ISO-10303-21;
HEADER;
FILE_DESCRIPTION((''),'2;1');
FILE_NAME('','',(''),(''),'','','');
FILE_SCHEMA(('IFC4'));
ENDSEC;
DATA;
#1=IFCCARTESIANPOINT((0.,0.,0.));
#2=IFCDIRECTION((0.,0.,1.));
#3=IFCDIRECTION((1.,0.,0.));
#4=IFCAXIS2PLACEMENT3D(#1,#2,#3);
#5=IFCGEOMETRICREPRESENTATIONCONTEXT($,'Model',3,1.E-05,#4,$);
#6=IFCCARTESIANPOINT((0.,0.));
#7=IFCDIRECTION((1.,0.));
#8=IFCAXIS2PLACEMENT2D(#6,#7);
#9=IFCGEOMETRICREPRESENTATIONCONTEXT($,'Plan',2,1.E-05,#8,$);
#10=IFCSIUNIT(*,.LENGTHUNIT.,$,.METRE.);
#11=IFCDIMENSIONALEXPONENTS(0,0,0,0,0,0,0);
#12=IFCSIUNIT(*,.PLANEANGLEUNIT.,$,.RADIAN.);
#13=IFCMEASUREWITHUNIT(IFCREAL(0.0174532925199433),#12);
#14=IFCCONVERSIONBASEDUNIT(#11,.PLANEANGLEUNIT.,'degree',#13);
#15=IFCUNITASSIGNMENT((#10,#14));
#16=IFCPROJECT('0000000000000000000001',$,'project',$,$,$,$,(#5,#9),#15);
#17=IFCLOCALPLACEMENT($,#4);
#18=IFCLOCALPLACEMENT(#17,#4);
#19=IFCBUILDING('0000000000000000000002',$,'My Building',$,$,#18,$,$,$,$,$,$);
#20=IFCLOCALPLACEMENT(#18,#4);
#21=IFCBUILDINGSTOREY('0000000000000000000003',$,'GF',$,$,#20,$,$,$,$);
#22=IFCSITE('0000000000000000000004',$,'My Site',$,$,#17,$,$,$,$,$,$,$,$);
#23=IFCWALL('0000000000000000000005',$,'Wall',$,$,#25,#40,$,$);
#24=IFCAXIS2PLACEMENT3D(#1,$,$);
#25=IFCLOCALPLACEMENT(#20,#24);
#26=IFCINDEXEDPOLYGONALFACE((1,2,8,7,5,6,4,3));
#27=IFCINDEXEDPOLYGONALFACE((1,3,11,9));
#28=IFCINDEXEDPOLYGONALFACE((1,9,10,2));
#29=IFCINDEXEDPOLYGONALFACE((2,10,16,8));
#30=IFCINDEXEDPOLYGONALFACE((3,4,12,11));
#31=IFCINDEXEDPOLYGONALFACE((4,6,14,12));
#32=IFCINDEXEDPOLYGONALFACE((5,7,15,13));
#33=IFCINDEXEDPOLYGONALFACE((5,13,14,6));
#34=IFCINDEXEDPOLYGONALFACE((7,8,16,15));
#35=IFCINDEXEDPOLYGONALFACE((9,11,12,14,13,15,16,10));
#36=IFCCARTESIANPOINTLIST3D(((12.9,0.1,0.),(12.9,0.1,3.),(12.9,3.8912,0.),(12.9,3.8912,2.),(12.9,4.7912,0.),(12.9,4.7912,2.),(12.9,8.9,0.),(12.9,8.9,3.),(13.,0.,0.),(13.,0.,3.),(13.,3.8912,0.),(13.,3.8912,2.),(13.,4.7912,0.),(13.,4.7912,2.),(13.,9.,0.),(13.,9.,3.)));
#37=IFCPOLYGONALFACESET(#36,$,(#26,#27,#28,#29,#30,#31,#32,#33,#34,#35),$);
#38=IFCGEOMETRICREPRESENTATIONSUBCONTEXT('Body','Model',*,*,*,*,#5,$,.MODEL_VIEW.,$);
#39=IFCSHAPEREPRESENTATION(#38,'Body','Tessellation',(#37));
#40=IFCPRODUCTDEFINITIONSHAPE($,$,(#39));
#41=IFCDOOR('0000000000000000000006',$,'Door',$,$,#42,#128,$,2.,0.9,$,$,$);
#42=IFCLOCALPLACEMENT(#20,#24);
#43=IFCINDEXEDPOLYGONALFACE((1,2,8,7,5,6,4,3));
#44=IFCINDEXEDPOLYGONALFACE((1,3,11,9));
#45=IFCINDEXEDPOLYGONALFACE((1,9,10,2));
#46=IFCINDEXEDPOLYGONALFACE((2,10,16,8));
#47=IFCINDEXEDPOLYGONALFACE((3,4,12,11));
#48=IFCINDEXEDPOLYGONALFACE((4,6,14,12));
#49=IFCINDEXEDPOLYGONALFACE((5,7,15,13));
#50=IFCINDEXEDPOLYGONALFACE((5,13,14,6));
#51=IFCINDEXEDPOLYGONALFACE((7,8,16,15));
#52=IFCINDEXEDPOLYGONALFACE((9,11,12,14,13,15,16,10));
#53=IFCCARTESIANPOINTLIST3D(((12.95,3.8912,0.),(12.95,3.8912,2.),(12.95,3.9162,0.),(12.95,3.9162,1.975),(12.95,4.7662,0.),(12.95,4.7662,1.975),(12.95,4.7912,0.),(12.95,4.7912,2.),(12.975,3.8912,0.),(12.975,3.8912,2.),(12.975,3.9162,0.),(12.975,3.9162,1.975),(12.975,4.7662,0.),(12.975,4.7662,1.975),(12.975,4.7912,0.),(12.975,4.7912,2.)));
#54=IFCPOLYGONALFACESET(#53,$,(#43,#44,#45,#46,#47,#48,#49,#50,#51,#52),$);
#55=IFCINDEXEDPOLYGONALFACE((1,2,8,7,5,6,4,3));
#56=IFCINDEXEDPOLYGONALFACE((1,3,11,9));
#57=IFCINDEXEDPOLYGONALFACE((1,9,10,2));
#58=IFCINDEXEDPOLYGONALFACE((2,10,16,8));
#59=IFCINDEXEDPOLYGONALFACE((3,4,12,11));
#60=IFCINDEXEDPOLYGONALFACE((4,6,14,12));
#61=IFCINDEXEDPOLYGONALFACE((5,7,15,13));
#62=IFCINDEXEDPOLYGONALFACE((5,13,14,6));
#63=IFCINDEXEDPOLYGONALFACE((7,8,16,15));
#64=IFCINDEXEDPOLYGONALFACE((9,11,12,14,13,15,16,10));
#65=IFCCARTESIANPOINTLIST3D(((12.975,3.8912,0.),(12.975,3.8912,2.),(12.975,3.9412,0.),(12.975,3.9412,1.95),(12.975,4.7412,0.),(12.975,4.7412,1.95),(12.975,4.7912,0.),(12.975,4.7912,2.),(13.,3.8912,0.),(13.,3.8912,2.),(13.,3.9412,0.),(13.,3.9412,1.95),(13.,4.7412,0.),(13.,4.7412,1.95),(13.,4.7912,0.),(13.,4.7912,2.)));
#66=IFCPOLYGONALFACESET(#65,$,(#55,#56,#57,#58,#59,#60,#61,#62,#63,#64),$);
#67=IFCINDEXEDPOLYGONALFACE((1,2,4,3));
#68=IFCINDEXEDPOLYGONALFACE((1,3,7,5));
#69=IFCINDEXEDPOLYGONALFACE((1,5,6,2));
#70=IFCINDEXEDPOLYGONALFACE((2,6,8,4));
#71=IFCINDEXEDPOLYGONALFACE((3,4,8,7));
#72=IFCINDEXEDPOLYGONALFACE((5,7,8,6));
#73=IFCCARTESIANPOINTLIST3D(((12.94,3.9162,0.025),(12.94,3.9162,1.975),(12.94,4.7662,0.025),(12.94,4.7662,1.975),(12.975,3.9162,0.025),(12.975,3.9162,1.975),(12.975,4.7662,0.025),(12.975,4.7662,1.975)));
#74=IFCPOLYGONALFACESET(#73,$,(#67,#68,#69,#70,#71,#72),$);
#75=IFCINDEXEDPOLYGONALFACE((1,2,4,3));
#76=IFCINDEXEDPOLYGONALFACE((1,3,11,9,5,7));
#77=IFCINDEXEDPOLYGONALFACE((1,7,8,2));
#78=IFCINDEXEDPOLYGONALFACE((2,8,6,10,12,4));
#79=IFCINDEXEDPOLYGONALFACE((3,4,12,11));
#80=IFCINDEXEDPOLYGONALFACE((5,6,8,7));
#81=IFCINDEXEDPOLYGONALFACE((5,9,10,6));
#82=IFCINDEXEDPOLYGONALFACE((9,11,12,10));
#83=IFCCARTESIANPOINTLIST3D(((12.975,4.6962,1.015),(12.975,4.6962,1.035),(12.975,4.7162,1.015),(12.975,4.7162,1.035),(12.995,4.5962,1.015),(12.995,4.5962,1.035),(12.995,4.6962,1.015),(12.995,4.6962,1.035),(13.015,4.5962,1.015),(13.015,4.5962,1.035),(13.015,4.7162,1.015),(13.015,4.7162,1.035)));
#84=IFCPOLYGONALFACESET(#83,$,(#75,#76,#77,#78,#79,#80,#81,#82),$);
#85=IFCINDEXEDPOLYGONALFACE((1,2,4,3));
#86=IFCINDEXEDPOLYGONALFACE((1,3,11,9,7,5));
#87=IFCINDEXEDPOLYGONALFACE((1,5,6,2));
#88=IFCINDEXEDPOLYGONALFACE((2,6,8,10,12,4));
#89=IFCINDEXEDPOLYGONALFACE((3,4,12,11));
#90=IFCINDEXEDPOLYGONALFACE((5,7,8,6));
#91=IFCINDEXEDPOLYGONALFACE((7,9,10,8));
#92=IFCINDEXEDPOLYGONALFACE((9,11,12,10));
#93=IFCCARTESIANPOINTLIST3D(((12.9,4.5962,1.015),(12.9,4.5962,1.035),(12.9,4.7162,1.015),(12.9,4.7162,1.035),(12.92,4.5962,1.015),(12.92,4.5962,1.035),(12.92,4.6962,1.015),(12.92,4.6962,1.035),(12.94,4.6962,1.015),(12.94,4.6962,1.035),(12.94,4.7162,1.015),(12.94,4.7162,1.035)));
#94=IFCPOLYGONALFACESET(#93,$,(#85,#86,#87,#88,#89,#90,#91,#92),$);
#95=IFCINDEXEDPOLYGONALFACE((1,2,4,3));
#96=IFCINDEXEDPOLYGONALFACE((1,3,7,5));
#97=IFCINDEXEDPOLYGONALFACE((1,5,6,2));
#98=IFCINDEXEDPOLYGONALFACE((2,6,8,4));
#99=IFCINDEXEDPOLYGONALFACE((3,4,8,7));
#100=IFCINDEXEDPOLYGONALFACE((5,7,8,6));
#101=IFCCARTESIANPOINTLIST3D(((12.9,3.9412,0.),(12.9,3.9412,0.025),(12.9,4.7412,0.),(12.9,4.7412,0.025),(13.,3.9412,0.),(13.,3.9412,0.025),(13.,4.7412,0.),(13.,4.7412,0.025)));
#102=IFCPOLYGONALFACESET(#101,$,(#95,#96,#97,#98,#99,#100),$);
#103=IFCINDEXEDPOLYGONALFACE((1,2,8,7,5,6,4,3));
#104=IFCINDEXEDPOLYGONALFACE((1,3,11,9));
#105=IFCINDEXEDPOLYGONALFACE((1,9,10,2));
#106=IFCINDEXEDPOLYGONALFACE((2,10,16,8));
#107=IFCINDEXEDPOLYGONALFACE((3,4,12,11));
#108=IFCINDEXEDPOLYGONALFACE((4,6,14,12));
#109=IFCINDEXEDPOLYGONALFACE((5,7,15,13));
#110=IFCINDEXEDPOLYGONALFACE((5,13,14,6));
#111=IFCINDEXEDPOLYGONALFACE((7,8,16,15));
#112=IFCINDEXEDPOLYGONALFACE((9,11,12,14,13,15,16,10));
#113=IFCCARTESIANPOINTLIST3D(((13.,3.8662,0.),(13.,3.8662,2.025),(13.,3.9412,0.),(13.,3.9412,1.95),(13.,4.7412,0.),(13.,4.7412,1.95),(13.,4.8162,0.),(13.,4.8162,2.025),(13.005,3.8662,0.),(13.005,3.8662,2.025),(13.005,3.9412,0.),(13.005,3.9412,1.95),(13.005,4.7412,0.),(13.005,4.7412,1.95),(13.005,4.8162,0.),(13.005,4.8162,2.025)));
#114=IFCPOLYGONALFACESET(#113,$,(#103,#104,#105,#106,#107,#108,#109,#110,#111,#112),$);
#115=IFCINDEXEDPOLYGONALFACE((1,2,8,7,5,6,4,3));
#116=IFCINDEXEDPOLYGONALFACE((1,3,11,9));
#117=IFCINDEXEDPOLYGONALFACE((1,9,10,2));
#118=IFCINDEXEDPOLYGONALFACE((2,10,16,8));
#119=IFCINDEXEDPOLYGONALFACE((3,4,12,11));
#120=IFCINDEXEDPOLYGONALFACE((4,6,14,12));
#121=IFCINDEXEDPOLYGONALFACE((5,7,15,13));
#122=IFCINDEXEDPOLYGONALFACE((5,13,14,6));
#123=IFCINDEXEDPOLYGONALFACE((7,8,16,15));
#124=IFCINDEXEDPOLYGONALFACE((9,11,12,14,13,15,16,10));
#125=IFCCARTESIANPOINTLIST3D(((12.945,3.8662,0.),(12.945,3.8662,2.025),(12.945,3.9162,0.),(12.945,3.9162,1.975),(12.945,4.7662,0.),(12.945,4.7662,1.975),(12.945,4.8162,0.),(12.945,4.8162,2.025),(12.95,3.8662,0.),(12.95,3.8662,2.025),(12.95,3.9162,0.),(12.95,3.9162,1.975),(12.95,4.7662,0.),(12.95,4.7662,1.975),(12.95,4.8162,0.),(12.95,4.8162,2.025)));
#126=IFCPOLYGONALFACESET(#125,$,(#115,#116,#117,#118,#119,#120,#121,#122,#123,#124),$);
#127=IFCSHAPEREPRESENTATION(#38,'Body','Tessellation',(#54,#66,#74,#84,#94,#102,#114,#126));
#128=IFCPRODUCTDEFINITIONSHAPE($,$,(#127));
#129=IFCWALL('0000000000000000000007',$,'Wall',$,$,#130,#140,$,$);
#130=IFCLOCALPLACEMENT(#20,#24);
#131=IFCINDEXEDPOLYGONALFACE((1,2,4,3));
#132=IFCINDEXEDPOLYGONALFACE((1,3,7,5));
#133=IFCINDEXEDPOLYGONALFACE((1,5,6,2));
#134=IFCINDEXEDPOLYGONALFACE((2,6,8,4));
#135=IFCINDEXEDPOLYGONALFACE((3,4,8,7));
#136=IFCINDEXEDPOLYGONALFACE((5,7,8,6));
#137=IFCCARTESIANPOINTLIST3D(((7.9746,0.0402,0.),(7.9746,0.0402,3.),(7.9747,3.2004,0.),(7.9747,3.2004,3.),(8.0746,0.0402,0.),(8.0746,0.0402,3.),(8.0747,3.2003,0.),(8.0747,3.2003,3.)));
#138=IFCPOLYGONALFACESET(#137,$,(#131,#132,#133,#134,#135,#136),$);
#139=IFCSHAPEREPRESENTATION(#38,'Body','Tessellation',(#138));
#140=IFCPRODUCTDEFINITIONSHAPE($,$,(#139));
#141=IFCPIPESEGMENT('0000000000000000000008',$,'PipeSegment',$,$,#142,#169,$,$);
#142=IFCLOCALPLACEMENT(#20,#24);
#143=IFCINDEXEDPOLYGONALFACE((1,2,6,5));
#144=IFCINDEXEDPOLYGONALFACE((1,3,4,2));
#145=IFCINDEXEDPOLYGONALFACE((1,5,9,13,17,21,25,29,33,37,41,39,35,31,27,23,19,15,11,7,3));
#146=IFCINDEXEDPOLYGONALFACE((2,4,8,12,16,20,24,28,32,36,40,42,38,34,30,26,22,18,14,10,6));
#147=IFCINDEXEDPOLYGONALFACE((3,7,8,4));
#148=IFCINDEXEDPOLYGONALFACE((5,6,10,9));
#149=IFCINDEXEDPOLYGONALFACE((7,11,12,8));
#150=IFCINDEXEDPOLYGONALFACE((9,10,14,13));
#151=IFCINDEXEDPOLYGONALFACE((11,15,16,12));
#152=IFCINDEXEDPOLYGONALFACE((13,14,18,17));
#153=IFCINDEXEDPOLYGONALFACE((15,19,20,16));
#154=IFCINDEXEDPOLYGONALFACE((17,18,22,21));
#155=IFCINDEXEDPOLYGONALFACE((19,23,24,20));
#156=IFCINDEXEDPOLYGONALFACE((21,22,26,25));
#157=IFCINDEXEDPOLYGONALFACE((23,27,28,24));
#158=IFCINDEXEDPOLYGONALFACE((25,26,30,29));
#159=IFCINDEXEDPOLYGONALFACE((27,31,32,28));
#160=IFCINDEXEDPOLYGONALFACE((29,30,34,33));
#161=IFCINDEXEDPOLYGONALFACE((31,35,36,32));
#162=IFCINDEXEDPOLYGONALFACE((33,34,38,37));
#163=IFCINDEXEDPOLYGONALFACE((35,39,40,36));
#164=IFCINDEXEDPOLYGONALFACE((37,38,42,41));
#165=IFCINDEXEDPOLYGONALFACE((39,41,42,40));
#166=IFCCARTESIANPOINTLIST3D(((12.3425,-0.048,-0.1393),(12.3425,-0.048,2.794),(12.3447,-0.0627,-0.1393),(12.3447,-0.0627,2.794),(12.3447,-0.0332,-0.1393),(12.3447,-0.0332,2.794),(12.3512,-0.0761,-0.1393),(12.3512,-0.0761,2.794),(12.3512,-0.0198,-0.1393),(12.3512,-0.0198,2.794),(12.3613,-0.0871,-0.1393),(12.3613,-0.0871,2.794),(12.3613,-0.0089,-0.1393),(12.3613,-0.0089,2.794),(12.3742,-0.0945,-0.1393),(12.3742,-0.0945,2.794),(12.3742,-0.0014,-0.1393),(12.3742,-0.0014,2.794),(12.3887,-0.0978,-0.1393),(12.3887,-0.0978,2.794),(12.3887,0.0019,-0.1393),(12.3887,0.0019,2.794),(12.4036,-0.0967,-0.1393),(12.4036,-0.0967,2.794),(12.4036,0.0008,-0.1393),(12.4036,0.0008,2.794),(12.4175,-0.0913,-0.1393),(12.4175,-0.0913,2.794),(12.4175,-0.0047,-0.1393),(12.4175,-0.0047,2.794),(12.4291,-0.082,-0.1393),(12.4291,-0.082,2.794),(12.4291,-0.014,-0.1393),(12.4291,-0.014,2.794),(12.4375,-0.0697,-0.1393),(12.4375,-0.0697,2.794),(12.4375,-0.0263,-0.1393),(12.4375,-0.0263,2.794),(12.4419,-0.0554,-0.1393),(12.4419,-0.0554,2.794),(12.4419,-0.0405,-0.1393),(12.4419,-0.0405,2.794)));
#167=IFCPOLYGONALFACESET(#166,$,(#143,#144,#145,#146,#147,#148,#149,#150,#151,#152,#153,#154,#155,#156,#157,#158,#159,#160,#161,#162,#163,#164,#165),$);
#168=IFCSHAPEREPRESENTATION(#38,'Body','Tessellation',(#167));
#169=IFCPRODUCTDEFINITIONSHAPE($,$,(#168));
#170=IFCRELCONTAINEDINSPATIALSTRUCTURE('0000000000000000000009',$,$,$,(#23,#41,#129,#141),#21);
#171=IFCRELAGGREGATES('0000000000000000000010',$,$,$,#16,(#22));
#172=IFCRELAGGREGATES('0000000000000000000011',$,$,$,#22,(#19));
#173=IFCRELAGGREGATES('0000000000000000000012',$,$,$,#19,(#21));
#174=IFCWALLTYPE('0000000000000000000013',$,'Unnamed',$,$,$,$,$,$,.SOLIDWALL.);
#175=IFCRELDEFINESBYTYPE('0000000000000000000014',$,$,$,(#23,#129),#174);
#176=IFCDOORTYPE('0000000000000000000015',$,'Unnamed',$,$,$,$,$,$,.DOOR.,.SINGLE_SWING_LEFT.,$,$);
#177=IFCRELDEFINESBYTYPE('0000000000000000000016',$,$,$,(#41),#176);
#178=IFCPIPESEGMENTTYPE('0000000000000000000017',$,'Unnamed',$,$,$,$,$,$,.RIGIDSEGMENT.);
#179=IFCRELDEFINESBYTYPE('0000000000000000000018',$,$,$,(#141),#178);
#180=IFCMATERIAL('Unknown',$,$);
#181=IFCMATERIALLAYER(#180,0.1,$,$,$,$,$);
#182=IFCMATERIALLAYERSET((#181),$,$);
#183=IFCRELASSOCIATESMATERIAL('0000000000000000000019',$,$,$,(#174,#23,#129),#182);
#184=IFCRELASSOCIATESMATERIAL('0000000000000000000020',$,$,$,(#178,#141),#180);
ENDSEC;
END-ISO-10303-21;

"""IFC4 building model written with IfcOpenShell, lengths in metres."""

from ifc_helpers import new_model, entity, si_unit, converted_unit, frame, origin_with_axes, origin_2d_with_axis, place, context, subcontext, project, spatial, line, indexed_curve, circle, outline, extrude, shape, source, transform, mapped, material, layer, layer_set, layer_usage, material_profile, profile_set, profile_usage, type_object, type_shapes, element, fill, save


model = new_model("IFC4")

# Units and contexts
model_context = context("Model", 3, precision=1e-05, world=origin_with_axes())
plan_context = context("Plan", 2, precision=1e-05, world=origin_2d_with_axis())
body_context_1 = subcontext(model_context, "Body", "Model", "MODEL_VIEW")
body_context_2 = subcontext(plan_context, "Body", "Plan", "PLAN_VIEW")
ifc_project = project(units=[si_unit("LENGTHUNIT", "METRE"), converted_unit("PLANEANGLEUNIT", "degree", entity("IfcReal", 0.0174532925199433), si_unit("PLANEANGLEUNIT", "RADIAN"), dimensions=[0, 0, 0, 0, 0, 0, 0])], contexts=[model_context, plan_context])

# Site, building, storey
site_placement = place(None, origin_with_axes())
site = spatial("IfcSite", under=ifc_project, at=site_placement, Name="My Site")
building_placement = place(site_placement, origin_with_axes())
building = spatial("IfcBuilding", under=site, at=building_placement, Name="My Building")
storey_placement = place(building_placement, origin_with_axes())
storey = spatial("IfcBuildingStorey", under=building, at=storey_placement, Name="GF")

# Wall, opening, door
ifc_material = material(Name="Unknown")
ifc_layer = layer(ifc_material, 0.1)
ifc_layer_set = layer_set([ifc_layer])
ifc_layer_usage_1 = layer_usage(ifc_layer_set, "AXIS2", "POSITIVE", 0.0)
wall_type = type_object("IfcWallType", Name="Unnamed", PredefinedType="SOLIDWALL", material=ifc_layer_set)
wall_1_placement = place(storey_placement, frame((13.0, 0.0, 0.0), z_axis=(0.0, 0.0, 1.0), x_axis=(0.0, 1.0, 0.0)))
wall_1 = element("IfcWall", 1, at=wall_1_placement, inside=storey, type_object=wall_type, material=ifc_layer_usage_1, Name="Wall", context=body_context_1, shape_type="SweptSolid", body=[
    extrude(outline(indexed_curve([(0.0, 0.0), (0.1, 0.1), (8.9, 0.1), (9.0, 0.0)], segments=[line(1, 2, 3, 4, 1)])), origin_with_axes(), (0.0, 0.0, 1.0), 3.0),
])
shared_shape_1 = source(origin_with_axes(), body_context_1, "Body", "SweptSolid", [
    extrude(outline(indexed_curve([(0.0, 0.0), (0.9, 0.0), (0.9, 2.0), (0.0, 2.0)], segments=[line(1, 2, 3, 4, 1)])), frame((0.0, -0.6, 0.0), z_axis=(0.0, -1.0, 0.0), x_axis=(1.0, 0.0, 0.0)), (0.0, 0.0, -1.0), 1.2),
])
opening_1_placement = place(wall_1_placement, frame((3.8912, 0.0, 0.0), z_axis=(0.0, 0.0, 1.0), x_axis=(1.0, 0.0, 0.0)))
opening_1 = element("IfcOpeningElement", 2, at=opening_1_placement, cuts=wall_1, PredefinedType="OPENING", context=body_context_1, shape_type="MappedRepresentation", body=[
    mapped(shared_shape_1, transform((0.0, 0.0, 0.0), x_axis=(1.0, 0.0, 0.0), y_axis=(0.0, 1.0, 0.0), z_axis=(0.0, 0.0, 1.0), scale=1.0)),
])
door_type = type_object("IfcDoorType", Name="Unnamed", OperationType="SINGLE_SWING_LEFT", PredefinedType="DOOR")
shared_shape_2 = source(origin_with_axes(), body_context_1, "Body", "SweptSolid", [
    extrude(outline(indexed_curve([(0.0, 0.0), (0.0, 2.0), (0.9, 2.0), (0.9, 0.0), (0.875, 0.0), (0.875, 1.975), (0.025, 1.975), (0.025, 0.0)], segments=[line(1, 2, 3, 4, 5, 6, 7, 8, 1)])), frame((0.0, 0.025, 0.0), z_axis=(0.0, -1.0, 0.0), x_axis=(1.0, 0.0, 0.0)), (0.0, 0.0, -1.0), 0.025),
    extrude(outline(indexed_curve([(0.0, 0.0), (0.0, 2.0), (0.9, 2.0), (0.9, 0.0), (0.85, 0.0), (0.85, 1.95), (0.05, 1.95), (0.05, 0.0)], segments=[line(1, 2, 3, 4, 5, 6, 7, 8, 1)])), frame((0.0, 0.0, 0.0), z_axis=(0.0, -1.0, 0.0), x_axis=(1.0, 0.0, 0.0)), (0.0, 0.0, -1.0), 0.025),
    extrude(outline(indexed_curve([(0.0, 0.0), (0.85, 0.0), (0.85, 0.035), (0.0, 0.035)], segments=[line(1, 2, 3, 4, 1)])), frame((0.025, 0.025, 0.025), z_axis=(0.0, 0.0, 1.0), x_axis=(1.0, 0.0, 0.0)), (0.0, 0.0, 1.0), 1.95),
    extrude(outline(indexed_curve([(0.0, 0.0), (0.0, -0.04), (-0.12, -0.04), (-0.12, -0.02), (-0.02, -0.02), (-0.02, 0.0)], segments=[line(1, 2, 3, 4, 5, 6, 1)])), frame((0.825, 0.025, 1.015), z_axis=(0.0, 0.0, 1.0), x_axis=(1.0, 0.0, 0.0)), (0.0, 0.0, 1.0), 0.02),
    extrude(outline(indexed_curve([(0.0, 0.0), (0.0, 0.04), (-0.12, 0.04), (-0.12, 0.02), (-0.02, 0.02), (-0.02, 0.0)], segments=[line(1, 2, 3, 4, 5, 6, 1)])), frame((0.825, 0.06, 1.015), z_axis=(0.0, 0.0, 1.0), x_axis=(1.0, 0.0, 0.0)), (0.0, 0.0, 1.0), 0.02),
    extrude(outline(indexed_curve([(0.0, 0.0), (0.8, 0.0), (0.8, 0.1), (0.0, 0.1)], segments=[line(1, 2, 3, 4, 1)])), frame((0.05, 0.0, 0.0), z_axis=(0.0, 0.0, 1.0), x_axis=(1.0, 0.0, 0.0)), (0.0, 0.0, 1.0), 0.025),
    extrude(outline(indexed_curve([(0.0, 0.0), (0.0, 2.025), (0.95, 2.025), (0.95, 0.0), (0.875, 0.0), (0.875, 1.95), (0.075, 1.95), (0.075, 0.0)], segments=[line(1, 2, 3, 4, 5, 6, 7, 8, 1)])), frame((-0.025, -0.005, 0.0), z_axis=(0.0, -1.0, 0.0), x_axis=(1.0, 0.0, 0.0)), (0.0, 0.0, -1.0), 0.005),
    extrude(outline(indexed_curve([(0.0, 0.0), (0.0, 2.025), (0.95, 2.025), (0.95, 0.0), (0.9, 0.0), (0.9, 1.975), (0.05, 1.975), (0.05, 0.0)], segments=[line(1, 2, 3, 4, 5, 6, 7, 8, 1)])), frame((-0.025, 0.05, 0.0), z_axis=(0.0, -1.0, 0.0), x_axis=(1.0, 0.0, 0.0)), (0.0, 0.0, -1.0), 0.005),
])
shared_shape_3 = source(origin_with_axes(), body_context_2, "Body", "Curve2D", [
    entity("IfcIndexedPolyCurve", entity("IfcCartesianPointList2D", [[0.0, 0.0], [0.0, 0.05], [0.025, 0.05], [0.025, 0.025], [0.05, 0.025], [0.05, 0.0]]), [entity("IfcLineIndex", [1, 2, 3, 4, 5, 6, 1])]),
    entity("IfcIndexedPolyCurve", entity("IfcCartesianPointList2D", [[0.9, 0.0], [0.9, 0.05], [0.875, 0.05], [0.875, 0.025], [0.85, 0.025], [0.85, 0.0]]), [entity("IfcLineIndex", [1, 2, 3, 4, 5, 6, 1])]),
    entity("IfcTrimmedCurve", entity("IfcEllipse", entity("IfcAxis2Placement2D", entity("IfcCartesianPoint", [0.06, 0.05]), entity("IfcDirection", [1.0, 0.0])), 0.815, 0.85), [entity("IfcCartesianPoint", [0.875, 0.05])], [entity("IfcCartesianPoint", [0.06, 0.9])], True, "CARTESIAN"),
    entity("IfcIndexedPolyCurve", entity("IfcCartesianPointList2D", [[0.025, 0.05], [0.06, 0.05], [0.06, 0.9], [0.025, 0.9]]), [entity("IfcLineIndex", [1, 2, 3, 4, 1])]),
])
type_shapes(door_type, [shared_shape_2, shared_shape_3])
door_placement = place(opening_1_placement, frame((0.0, 0.0, 0.0), z_axis=(0.0, 0.0, 1.0), x_axis=(1.0, 0.0, 0.0)))
door = element("IfcDoor", 3, at=door_placement, inside=storey, type_object=door_type, Name="Door", OverallHeight=2.0, OverallWidth=0.9, shapes=[
    shape(body_context_1, "Body", "MappedRepresentation", [mapped(shared_shape_2, transform((0.0, 0.0, 0.0), x_axis=(1.0, 0.0, 0.0), y_axis=(0.0, 1.0, 0.0), z_axis=(0.0, 0.0, 1.0), scale=1.0))]),
    shape(body_context_2, "Body", "MappedRepresentation", [mapped(shared_shape_3, transform((0.0, 0.0, 0.0), x_axis=(1.0, 0.0, 0.0), y_axis=(0.0, 1.0, 0.0), z_axis=(0.0, 0.0, 1.0), scale=1.0))]),
])
fill(opening_1, door)

# Wall
ifc_layer_usage_2 = layer_usage(ifc_layer_set, "AXIS2", "POSITIVE", 0.0)
wall_2_placement = place(storey_placement, frame((8.0746, 0.0402, 0.0), z_axis=(0.0, 0.0, 1.0), x_axis=(0.000013, 1.0, 0.0)))
element("IfcWall", 4, at=wall_2_placement, inside=storey, type_object=wall_type, material=ifc_layer_usage_2, Name="Wall", context=body_context_1, shape_type="SweptSolid", body=[
    extrude(outline(indexed_curve([(0.0, 0.0), (0.0, 0.1), (3.1602, 0.1), (3.1602, 0.0)], segments=[line(1, 2, 3, 4, 1)])), origin_with_axes(), (0.0, 0.0, 1.0), 3.0),
])

# Pipe segment
ifc_material_profile = material_profile(ifc_material, circle(Radius=0.05))
ifc_profile_set = profile_set([ifc_material_profile])
ifc_profile_usage_1 = profile_usage(ifc_profile_set, cardinal=5)
pipe_segment_type = type_object("IfcPipeSegmentType", Name="Unnamed", PredefinedType="RIGIDSEGMENT", material=ifc_profile_set)
pipe_segment_1_placement = place(storey_placement, frame((12.3925, -0.048, -0.1393), z_axis=(0.0, 0.0, 1.0), x_axis=(-1.0, 0.0, 0.0)))
element("IfcPipeSegment", 5, at=pipe_segment_1_placement, inside=storey, type_object=pipe_segment_type, material=ifc_profile_usage_1, Name="PipeSegment", context=body_context_1, shape_type="SweptSolid", body=[
    extrude(circle(Radius=0.05), origin_with_axes(), (0.0, 0.0, 1.0), 2.9333),
])

save(model, "model.ifc")
